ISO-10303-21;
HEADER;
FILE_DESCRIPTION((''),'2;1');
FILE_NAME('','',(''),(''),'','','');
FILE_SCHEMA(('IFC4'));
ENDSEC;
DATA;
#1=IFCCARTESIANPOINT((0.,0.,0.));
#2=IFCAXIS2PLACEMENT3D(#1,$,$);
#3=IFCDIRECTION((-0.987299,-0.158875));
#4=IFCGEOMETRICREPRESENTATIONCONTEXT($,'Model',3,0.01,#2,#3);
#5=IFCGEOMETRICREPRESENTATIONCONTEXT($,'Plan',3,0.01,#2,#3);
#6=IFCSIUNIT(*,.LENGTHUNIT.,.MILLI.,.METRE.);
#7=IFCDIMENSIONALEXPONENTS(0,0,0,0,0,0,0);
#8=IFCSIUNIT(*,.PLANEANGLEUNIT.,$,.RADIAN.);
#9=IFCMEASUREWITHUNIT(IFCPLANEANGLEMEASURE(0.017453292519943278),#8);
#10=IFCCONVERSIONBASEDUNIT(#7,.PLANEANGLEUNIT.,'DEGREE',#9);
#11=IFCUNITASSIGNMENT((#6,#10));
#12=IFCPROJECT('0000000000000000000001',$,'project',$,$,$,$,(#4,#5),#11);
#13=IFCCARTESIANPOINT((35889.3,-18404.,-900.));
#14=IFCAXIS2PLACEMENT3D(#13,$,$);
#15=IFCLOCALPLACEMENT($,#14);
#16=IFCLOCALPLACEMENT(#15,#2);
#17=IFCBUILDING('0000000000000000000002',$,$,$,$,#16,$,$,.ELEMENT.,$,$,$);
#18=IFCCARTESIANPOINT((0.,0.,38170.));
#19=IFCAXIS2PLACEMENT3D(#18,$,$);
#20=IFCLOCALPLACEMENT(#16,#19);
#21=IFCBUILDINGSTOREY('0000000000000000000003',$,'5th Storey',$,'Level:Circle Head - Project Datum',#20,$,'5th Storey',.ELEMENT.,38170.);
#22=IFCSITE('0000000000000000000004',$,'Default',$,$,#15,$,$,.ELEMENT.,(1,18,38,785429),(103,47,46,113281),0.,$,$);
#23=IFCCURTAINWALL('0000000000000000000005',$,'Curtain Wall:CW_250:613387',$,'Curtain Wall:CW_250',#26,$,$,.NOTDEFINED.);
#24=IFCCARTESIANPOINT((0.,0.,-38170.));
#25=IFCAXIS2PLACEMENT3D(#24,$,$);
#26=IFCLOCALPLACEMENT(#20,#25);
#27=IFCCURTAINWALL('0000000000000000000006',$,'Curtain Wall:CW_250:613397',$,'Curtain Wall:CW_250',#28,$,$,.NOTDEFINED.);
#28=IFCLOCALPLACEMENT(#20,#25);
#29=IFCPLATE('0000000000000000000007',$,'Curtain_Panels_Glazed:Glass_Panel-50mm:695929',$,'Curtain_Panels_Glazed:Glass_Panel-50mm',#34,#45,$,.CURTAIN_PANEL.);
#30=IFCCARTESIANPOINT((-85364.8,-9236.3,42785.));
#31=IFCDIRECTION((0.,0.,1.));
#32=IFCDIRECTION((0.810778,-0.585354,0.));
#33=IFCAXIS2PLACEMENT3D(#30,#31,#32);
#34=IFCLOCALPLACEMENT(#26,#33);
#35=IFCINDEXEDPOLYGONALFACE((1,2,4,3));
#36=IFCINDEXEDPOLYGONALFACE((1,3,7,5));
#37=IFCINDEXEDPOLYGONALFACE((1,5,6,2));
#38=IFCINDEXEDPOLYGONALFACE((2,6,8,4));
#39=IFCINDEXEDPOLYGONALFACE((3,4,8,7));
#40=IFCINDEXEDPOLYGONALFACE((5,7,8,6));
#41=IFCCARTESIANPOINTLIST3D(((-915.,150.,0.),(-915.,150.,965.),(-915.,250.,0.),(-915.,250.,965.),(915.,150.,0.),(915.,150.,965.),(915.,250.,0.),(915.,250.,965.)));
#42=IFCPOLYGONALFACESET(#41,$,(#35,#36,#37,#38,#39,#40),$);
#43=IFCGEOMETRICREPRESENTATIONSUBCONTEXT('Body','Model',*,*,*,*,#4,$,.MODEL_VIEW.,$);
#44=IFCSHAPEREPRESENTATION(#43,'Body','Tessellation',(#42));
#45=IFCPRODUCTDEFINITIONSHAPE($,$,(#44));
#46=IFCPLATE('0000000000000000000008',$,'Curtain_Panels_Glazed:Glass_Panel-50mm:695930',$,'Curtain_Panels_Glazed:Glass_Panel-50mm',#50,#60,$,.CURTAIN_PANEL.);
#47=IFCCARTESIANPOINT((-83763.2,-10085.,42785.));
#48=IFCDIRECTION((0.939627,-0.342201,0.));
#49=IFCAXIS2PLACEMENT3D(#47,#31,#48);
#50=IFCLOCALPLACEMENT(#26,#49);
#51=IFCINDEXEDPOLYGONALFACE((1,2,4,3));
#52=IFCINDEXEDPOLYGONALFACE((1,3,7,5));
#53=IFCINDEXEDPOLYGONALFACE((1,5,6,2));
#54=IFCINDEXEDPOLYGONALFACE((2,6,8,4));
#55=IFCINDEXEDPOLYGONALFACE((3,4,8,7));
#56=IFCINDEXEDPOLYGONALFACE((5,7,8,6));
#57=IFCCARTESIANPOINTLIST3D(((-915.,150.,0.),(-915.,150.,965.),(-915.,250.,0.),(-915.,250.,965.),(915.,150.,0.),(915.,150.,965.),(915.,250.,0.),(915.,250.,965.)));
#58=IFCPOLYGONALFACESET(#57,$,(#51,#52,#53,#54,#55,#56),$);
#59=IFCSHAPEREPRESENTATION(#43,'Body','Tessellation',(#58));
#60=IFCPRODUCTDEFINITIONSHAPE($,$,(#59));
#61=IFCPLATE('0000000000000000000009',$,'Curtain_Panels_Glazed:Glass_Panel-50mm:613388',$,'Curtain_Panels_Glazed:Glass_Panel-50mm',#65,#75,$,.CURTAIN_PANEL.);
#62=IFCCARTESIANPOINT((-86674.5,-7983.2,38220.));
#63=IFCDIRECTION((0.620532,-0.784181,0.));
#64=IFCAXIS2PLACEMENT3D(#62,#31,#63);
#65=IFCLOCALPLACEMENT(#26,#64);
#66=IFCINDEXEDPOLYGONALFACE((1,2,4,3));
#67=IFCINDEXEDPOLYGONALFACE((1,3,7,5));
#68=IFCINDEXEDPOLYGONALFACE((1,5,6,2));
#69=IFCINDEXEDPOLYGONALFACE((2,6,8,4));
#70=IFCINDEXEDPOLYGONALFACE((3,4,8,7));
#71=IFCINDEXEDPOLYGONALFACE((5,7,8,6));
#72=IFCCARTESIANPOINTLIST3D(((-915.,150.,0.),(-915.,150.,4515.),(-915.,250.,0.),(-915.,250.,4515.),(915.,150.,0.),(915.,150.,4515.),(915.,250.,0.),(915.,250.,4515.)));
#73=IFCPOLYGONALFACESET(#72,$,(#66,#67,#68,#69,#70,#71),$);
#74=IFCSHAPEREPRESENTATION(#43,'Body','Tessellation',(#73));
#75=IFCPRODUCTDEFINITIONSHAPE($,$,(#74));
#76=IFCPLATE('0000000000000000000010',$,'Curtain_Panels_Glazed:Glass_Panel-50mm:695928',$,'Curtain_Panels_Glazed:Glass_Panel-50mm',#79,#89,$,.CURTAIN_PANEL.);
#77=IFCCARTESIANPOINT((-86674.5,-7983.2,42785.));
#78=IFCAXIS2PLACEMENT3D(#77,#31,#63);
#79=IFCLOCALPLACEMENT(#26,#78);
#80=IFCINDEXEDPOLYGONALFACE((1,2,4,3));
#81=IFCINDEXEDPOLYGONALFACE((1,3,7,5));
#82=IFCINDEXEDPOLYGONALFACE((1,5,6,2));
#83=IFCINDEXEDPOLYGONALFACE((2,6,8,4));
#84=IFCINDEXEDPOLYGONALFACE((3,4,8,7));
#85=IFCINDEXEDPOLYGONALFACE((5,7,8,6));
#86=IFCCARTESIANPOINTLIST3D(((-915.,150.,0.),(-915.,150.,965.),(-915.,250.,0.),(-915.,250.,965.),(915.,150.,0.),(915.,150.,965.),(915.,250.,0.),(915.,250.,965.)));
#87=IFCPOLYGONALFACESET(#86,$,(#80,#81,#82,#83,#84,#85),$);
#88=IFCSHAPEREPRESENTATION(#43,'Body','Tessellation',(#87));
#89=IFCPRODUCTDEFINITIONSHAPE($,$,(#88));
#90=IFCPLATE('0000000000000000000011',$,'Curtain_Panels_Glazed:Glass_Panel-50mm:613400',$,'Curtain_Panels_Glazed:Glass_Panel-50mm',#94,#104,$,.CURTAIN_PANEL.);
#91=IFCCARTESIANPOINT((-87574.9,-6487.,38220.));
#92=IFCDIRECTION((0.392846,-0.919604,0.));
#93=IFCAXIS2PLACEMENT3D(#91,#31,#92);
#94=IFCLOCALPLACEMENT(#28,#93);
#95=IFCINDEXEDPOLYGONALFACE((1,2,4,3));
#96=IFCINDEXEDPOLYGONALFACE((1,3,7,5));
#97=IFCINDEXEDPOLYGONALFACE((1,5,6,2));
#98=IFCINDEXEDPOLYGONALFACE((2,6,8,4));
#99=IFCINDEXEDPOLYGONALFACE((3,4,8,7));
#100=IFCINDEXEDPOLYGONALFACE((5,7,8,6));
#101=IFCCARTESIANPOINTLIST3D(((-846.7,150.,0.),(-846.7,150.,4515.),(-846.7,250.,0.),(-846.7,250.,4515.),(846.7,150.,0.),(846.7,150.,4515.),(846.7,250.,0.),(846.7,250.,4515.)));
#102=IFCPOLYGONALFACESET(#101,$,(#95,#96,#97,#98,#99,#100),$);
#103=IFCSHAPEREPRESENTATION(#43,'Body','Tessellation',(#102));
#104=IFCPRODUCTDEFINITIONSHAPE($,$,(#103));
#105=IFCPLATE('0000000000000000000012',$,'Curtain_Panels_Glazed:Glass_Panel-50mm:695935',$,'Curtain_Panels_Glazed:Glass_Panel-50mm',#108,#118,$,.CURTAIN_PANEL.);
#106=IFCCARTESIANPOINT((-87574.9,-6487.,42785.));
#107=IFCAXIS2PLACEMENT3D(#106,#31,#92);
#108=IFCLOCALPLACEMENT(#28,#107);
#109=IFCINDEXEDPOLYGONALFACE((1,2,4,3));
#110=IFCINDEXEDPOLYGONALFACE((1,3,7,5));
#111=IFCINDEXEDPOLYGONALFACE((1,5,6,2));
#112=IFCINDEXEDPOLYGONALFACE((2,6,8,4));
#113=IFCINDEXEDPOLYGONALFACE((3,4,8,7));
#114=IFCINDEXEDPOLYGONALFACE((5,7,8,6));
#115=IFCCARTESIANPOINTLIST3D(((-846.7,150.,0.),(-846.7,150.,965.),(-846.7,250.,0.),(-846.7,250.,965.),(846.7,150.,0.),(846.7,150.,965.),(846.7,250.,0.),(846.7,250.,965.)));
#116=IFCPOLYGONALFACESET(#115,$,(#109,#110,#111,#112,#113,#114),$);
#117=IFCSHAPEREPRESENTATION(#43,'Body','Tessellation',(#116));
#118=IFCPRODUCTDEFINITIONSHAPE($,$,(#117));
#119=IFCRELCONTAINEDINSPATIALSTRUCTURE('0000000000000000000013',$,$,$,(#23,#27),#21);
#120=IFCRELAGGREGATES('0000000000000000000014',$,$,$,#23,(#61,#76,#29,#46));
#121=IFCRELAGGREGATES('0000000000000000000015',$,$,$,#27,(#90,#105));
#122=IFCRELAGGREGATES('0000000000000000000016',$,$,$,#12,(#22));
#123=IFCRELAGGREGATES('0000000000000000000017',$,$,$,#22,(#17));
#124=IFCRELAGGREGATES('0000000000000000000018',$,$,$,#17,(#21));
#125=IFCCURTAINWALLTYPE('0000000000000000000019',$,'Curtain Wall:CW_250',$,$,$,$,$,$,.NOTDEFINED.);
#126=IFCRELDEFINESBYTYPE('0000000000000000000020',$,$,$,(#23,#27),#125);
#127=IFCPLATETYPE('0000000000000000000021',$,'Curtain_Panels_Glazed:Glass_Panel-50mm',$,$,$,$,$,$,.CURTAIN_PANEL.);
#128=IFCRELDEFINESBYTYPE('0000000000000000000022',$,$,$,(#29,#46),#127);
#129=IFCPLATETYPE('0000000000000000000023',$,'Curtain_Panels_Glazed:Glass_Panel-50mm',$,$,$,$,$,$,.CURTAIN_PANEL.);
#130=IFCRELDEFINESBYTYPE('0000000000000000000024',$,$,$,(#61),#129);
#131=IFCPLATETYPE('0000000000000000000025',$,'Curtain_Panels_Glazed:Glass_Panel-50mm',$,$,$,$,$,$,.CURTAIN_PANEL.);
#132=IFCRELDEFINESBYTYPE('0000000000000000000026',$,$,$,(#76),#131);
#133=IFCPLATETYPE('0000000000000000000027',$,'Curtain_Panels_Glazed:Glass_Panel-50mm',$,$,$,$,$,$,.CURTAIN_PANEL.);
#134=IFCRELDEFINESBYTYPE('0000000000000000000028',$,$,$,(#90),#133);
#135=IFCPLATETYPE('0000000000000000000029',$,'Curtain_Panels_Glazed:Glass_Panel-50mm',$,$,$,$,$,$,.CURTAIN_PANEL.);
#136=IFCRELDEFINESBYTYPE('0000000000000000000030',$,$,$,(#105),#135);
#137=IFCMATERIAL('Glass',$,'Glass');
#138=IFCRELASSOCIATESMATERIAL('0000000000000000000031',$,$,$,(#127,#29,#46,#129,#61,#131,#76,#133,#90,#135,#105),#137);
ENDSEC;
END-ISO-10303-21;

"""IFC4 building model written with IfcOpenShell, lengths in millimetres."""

from ifc_helpers import new_model, entity, si_unit, converted_unit, direction, frame, origin, place, context, subcontext, project, spatial, indexed_curve, outline, extrude, source, transform, mapped, material, type_object, type_shapes, element, aggregate, save


model = new_model("IFC4")

# Units and contexts
model_context = context("Model", 3, precision=0.01, world=origin(), true_north=direction((-0.987299, -0.158875)))
plan_context = context("Plan", 3, precision=0.01, world=origin(), true_north=direction((-0.987299, -0.158875)))
body_context = subcontext(model_context, "Body", "Model", "MODEL_VIEW")
ifc_project = project(units=[si_unit("LENGTHUNIT", "METRE", prefix="MILLI"), converted_unit("PLANEANGLEUNIT", "DEGREE", entity("IfcPlaneAngleMeasure", 0.017453292519943278), si_unit("PLANEANGLEUNIT", "RADIAN"), dimensions=[0, 0, 0, 0, 0, 0, 0])], contexts=[model_context, plan_context])

# Site, building, storey
site_placement = place(None, frame((35889.3, -18404.0, -900.0)))
site = spatial("IfcSite", under=ifc_project, at=site_placement, Name="Default", CompositionType="ELEMENT", RefLatitude=(1, 18, 38, 785429), RefLongitude=(103, 47, 46, 113281), RefElevation=0.0)
building_placement = place(site_placement, origin())
building = spatial("IfcBuilding", under=site, at=building_placement, CompositionType="ELEMENT")
storey_placement = place(building_placement, frame((0.0, 0.0, 38170.0)))
storey = spatial("IfcBuildingStorey", under=building, at=storey_placement, Name="5th Storey", ObjectType="Level:Circle Head - Project Datum", LongName="5th Storey", CompositionType="ELEMENT", Elevation=38170.0)

# Curtain walls
curtain_wall_type = type_object("IfcCurtainWallType", Name="Curtain Wall:CW_250", PredefinedType="NOTDEFINED")
curtain_wall_1_placement = place(storey_placement, frame((0.0, 0.0, -38170.0)))
curtain_wall_1 = element("IfcCurtainWall", 1, at=curtain_wall_1_placement, inside=storey, type_object=curtain_wall_type, Name="Curtain Wall:CW_250:613387", ObjectType="Curtain Wall:CW_250", PredefinedType="NOTDEFINED")
curtain_wall_2_placement = place(storey_placement, frame((0.0, 0.0, -38170.0)))
curtain_wall_2 = element("IfcCurtainWall", 2, at=curtain_wall_2_placement, inside=storey, type_object=curtain_wall_type, Name="Curtain Wall:CW_250:613397", ObjectType="Curtain Wall:CW_250", PredefinedType="NOTDEFINED")

# Plates
ifc_material_1 = material(Name="Glass", Category="Glass")
plate_type_1 = type_object("IfcPlateType", Name="Curtain_Panels_Glazed:Glass_Panel-50mm", PredefinedType="CURTAIN_PANEL", material=ifc_material_1)
shared_shape_1 = source(origin(), body_context, "Body", "SweptSolid", [
    extrude(outline(indexed_curve([(-50.0, -915.0), (50.0, -915.0), (50.0, 915.0), (-50.0, 915.0), (-50.0, -915.0)], self_intersect=False)), frame((0.0, 200.0, 0.0), z_axis=(0.0, 0.0, 1.0), x_axis=(0.0, 1.0, 0.0)), (0.0, 0.0, 1.0), 965.0),
])
type_shapes(plate_type_1, [shared_shape_1])
plate_1_placement = place(curtain_wall_1_placement, frame((-85364.8, -9236.3, 42785.0), z_axis=(0.0, 0.0, 1.0), x_axis=(0.810778, -0.585354, 0.0)))
plate_1 = element("IfcPlate", 3, at=plate_1_placement, type_object=plate_type_1, material=ifc_material_1, Name="Curtain_Panels_Glazed:Glass_Panel-50mm:695929", ObjectType="Curtain_Panels_Glazed:Glass_Panel-50mm", PredefinedType="CURTAIN_PANEL", context=body_context, shape_type="MappedRepresentation", body=[
    mapped(shared_shape_1, transform((0.0, 0.0, 0.0), scale=1.0)),
])
plate_2_placement = place(curtain_wall_1_placement, frame((-83763.2, -10085.0, 42785.0), z_axis=(0.0, 0.0, 1.0), x_axis=(0.939627, -0.342201, 0.0)))
plate_2 = element("IfcPlate", 4, at=plate_2_placement, type_object=plate_type_1, material=ifc_material_1, Name="Curtain_Panels_Glazed:Glass_Panel-50mm:695930", ObjectType="Curtain_Panels_Glazed:Glass_Panel-50mm", PredefinedType="CURTAIN_PANEL", context=body_context, shape_type="MappedRepresentation", body=[
    mapped(shared_shape_1, transform((0.0, 0.0, 0.0), scale=1.0)),
])
plate_type_2 = type_object("IfcPlateType", Name="Curtain_Panels_Glazed:Glass_Panel-50mm", PredefinedType="CURTAIN_PANEL", material=ifc_material_1)
shared_shape_2 = source(origin(), body_context, "Body", "SweptSolid", [
    extrude(outline(indexed_curve([(-50.0, -915.0), (50.0, -915.0), (50.0, 915.0), (-50.0, 915.0), (-50.0, -915.0)], self_intersect=False)), frame((0.0, 200.0, 0.0), z_axis=(0.0, 0.0, 1.0), x_axis=(0.0, 1.0, 0.0)), (0.0, 0.0, 1.0), 4515.0),
])
type_shapes(plate_type_2, [shared_shape_2])
plate_3_placement = place(curtain_wall_1_placement, frame((-86674.5, -7983.2, 38220.0), z_axis=(0.0, 0.0, 1.0), x_axis=(0.620532, -0.784181, 0.0)))
plate_3 = element("IfcPlate", 5, at=plate_3_placement, type_object=plate_type_2, material=ifc_material_1, Name="Curtain_Panels_Glazed:Glass_Panel-50mm:613388", ObjectType="Curtain_Panels_Glazed:Glass_Panel-50mm", PredefinedType="CURTAIN_PANEL", context=body_context, shape_type="MappedRepresentation", body=[
    mapped(shared_shape_2, transform((0.0, 0.0, 0.0), scale=1.0)),
])
plate_type_3 = type_object("IfcPlateType", Name="Curtain_Panels_Glazed:Glass_Panel-50mm", PredefinedType="CURTAIN_PANEL", material=ifc_material_1)
shared_shape_3 = source(origin(), body_context, "Body", "SweptSolid", [
    extrude(outline(indexed_curve([(-50.0, -915.0), (50.0, -915.0), (50.0, 915.0), (-50.0, 915.0), (-50.0, -915.0)], self_intersect=False)), frame((0.0, 200.0, 0.0), z_axis=(0.0, 0.0, 1.0), x_axis=(0.0, 1.0, 0.0)), (0.0, 0.0, 1.0), 965.0),
])
type_shapes(plate_type_3, [shared_shape_3])
plate_4_placement = place(curtain_wall_1_placement, frame((-86674.5, -7983.2, 42785.0), z_axis=(0.0, 0.0, 1.0), x_axis=(0.620532, -0.784181, 0.0)))
plate_4 = element("IfcPlate", 6, at=plate_4_placement, type_object=plate_type_3, material=ifc_material_1, Name="Curtain_Panels_Glazed:Glass_Panel-50mm:695928", ObjectType="Curtain_Panels_Glazed:Glass_Panel-50mm", PredefinedType="CURTAIN_PANEL", context=body_context, shape_type="MappedRepresentation", body=[
    mapped(shared_shape_3, transform((0.0, 0.0, 0.0), scale=1.0)),
])
aggregate(curtain_wall_1, [plate_3, plate_4, plate_1, plate_2])
plate_type_4 = type_object("IfcPlateType", Name="Curtain_Panels_Glazed:Glass_Panel-50mm", PredefinedType="CURTAIN_PANEL", material=ifc_material_1)
shared_shape_4 = source(origin(), body_context, "Body", "SweptSolid", [
    extrude(outline(indexed_curve([(-50.0, -846.7), (50.0, -846.7), (50.0, 846.7), (-50.0, 846.7), (-50.0, -846.7)], self_intersect=False)), frame((0.0, 200.0, 0.0), z_axis=(0.0, 0.0, 1.0), x_axis=(0.0, 1.0, 0.0)), (0.0, 0.0, 1.0), 4515.0),
])
type_shapes(plate_type_4, [shared_shape_4])
plate_5_placement = place(curtain_wall_2_placement, frame((-87574.9, -6487.0, 38220.0), z_axis=(0.0, 0.0, 1.0), x_axis=(0.392846, -0.919604, 0.0)))
plate_5 = element("IfcPlate", 7, at=plate_5_placement, type_object=plate_type_4, material=ifc_material_1, Name="Curtain_Panels_Glazed:Glass_Panel-50mm:613400", ObjectType="Curtain_Panels_Glazed:Glass_Panel-50mm", PredefinedType="CURTAIN_PANEL", context=body_context, shape_type="MappedRepresentation", body=[
    mapped(shared_shape_4, transform((0.0, 0.0, 0.0), scale=1.0)),
])
plate_type_5 = type_object("IfcPlateType", Name="Curtain_Panels_Glazed:Glass_Panel-50mm", PredefinedType="CURTAIN_PANEL", material=ifc_material_1)
shared_shape_5 = source(origin(), body_context, "Body", "SweptSolid", [
    extrude(outline(indexed_curve([(-50.0, -846.7), (50.0, -846.7), (50.0, 846.7), (-50.0, 846.7), (-50.0, -846.7)], self_intersect=False)), frame((0.0, 200.0, 0.0), z_axis=(0.0, 0.0, 1.0), x_axis=(0.0, 1.0, 0.0)), (0.0, 0.0, 1.0), 965.0),
])
type_shapes(plate_type_5, [shared_shape_5])
plate_6_placement = place(curtain_wall_2_placement, frame((-87574.9, -6487.0, 42785.0), z_axis=(0.0, 0.0, 1.0), x_axis=(0.392846, -0.919604, 0.0)))
plate_6 = element("IfcPlate", 8, at=plate_6_placement, type_object=plate_type_5, material=ifc_material_1, Name="Curtain_Panels_Glazed:Glass_Panel-50mm:695935", ObjectType="Curtain_Panels_Glazed:Glass_Panel-50mm", PredefinedType="CURTAIN_PANEL", context=body_context, shape_type="MappedRepresentation", body=[
    mapped(shared_shape_5, transform((0.0, 0.0, 0.0), scale=1.0)),
])
aggregate(curtain_wall_2, [plate_5, plate_6])

save(model, "model.ifc")
